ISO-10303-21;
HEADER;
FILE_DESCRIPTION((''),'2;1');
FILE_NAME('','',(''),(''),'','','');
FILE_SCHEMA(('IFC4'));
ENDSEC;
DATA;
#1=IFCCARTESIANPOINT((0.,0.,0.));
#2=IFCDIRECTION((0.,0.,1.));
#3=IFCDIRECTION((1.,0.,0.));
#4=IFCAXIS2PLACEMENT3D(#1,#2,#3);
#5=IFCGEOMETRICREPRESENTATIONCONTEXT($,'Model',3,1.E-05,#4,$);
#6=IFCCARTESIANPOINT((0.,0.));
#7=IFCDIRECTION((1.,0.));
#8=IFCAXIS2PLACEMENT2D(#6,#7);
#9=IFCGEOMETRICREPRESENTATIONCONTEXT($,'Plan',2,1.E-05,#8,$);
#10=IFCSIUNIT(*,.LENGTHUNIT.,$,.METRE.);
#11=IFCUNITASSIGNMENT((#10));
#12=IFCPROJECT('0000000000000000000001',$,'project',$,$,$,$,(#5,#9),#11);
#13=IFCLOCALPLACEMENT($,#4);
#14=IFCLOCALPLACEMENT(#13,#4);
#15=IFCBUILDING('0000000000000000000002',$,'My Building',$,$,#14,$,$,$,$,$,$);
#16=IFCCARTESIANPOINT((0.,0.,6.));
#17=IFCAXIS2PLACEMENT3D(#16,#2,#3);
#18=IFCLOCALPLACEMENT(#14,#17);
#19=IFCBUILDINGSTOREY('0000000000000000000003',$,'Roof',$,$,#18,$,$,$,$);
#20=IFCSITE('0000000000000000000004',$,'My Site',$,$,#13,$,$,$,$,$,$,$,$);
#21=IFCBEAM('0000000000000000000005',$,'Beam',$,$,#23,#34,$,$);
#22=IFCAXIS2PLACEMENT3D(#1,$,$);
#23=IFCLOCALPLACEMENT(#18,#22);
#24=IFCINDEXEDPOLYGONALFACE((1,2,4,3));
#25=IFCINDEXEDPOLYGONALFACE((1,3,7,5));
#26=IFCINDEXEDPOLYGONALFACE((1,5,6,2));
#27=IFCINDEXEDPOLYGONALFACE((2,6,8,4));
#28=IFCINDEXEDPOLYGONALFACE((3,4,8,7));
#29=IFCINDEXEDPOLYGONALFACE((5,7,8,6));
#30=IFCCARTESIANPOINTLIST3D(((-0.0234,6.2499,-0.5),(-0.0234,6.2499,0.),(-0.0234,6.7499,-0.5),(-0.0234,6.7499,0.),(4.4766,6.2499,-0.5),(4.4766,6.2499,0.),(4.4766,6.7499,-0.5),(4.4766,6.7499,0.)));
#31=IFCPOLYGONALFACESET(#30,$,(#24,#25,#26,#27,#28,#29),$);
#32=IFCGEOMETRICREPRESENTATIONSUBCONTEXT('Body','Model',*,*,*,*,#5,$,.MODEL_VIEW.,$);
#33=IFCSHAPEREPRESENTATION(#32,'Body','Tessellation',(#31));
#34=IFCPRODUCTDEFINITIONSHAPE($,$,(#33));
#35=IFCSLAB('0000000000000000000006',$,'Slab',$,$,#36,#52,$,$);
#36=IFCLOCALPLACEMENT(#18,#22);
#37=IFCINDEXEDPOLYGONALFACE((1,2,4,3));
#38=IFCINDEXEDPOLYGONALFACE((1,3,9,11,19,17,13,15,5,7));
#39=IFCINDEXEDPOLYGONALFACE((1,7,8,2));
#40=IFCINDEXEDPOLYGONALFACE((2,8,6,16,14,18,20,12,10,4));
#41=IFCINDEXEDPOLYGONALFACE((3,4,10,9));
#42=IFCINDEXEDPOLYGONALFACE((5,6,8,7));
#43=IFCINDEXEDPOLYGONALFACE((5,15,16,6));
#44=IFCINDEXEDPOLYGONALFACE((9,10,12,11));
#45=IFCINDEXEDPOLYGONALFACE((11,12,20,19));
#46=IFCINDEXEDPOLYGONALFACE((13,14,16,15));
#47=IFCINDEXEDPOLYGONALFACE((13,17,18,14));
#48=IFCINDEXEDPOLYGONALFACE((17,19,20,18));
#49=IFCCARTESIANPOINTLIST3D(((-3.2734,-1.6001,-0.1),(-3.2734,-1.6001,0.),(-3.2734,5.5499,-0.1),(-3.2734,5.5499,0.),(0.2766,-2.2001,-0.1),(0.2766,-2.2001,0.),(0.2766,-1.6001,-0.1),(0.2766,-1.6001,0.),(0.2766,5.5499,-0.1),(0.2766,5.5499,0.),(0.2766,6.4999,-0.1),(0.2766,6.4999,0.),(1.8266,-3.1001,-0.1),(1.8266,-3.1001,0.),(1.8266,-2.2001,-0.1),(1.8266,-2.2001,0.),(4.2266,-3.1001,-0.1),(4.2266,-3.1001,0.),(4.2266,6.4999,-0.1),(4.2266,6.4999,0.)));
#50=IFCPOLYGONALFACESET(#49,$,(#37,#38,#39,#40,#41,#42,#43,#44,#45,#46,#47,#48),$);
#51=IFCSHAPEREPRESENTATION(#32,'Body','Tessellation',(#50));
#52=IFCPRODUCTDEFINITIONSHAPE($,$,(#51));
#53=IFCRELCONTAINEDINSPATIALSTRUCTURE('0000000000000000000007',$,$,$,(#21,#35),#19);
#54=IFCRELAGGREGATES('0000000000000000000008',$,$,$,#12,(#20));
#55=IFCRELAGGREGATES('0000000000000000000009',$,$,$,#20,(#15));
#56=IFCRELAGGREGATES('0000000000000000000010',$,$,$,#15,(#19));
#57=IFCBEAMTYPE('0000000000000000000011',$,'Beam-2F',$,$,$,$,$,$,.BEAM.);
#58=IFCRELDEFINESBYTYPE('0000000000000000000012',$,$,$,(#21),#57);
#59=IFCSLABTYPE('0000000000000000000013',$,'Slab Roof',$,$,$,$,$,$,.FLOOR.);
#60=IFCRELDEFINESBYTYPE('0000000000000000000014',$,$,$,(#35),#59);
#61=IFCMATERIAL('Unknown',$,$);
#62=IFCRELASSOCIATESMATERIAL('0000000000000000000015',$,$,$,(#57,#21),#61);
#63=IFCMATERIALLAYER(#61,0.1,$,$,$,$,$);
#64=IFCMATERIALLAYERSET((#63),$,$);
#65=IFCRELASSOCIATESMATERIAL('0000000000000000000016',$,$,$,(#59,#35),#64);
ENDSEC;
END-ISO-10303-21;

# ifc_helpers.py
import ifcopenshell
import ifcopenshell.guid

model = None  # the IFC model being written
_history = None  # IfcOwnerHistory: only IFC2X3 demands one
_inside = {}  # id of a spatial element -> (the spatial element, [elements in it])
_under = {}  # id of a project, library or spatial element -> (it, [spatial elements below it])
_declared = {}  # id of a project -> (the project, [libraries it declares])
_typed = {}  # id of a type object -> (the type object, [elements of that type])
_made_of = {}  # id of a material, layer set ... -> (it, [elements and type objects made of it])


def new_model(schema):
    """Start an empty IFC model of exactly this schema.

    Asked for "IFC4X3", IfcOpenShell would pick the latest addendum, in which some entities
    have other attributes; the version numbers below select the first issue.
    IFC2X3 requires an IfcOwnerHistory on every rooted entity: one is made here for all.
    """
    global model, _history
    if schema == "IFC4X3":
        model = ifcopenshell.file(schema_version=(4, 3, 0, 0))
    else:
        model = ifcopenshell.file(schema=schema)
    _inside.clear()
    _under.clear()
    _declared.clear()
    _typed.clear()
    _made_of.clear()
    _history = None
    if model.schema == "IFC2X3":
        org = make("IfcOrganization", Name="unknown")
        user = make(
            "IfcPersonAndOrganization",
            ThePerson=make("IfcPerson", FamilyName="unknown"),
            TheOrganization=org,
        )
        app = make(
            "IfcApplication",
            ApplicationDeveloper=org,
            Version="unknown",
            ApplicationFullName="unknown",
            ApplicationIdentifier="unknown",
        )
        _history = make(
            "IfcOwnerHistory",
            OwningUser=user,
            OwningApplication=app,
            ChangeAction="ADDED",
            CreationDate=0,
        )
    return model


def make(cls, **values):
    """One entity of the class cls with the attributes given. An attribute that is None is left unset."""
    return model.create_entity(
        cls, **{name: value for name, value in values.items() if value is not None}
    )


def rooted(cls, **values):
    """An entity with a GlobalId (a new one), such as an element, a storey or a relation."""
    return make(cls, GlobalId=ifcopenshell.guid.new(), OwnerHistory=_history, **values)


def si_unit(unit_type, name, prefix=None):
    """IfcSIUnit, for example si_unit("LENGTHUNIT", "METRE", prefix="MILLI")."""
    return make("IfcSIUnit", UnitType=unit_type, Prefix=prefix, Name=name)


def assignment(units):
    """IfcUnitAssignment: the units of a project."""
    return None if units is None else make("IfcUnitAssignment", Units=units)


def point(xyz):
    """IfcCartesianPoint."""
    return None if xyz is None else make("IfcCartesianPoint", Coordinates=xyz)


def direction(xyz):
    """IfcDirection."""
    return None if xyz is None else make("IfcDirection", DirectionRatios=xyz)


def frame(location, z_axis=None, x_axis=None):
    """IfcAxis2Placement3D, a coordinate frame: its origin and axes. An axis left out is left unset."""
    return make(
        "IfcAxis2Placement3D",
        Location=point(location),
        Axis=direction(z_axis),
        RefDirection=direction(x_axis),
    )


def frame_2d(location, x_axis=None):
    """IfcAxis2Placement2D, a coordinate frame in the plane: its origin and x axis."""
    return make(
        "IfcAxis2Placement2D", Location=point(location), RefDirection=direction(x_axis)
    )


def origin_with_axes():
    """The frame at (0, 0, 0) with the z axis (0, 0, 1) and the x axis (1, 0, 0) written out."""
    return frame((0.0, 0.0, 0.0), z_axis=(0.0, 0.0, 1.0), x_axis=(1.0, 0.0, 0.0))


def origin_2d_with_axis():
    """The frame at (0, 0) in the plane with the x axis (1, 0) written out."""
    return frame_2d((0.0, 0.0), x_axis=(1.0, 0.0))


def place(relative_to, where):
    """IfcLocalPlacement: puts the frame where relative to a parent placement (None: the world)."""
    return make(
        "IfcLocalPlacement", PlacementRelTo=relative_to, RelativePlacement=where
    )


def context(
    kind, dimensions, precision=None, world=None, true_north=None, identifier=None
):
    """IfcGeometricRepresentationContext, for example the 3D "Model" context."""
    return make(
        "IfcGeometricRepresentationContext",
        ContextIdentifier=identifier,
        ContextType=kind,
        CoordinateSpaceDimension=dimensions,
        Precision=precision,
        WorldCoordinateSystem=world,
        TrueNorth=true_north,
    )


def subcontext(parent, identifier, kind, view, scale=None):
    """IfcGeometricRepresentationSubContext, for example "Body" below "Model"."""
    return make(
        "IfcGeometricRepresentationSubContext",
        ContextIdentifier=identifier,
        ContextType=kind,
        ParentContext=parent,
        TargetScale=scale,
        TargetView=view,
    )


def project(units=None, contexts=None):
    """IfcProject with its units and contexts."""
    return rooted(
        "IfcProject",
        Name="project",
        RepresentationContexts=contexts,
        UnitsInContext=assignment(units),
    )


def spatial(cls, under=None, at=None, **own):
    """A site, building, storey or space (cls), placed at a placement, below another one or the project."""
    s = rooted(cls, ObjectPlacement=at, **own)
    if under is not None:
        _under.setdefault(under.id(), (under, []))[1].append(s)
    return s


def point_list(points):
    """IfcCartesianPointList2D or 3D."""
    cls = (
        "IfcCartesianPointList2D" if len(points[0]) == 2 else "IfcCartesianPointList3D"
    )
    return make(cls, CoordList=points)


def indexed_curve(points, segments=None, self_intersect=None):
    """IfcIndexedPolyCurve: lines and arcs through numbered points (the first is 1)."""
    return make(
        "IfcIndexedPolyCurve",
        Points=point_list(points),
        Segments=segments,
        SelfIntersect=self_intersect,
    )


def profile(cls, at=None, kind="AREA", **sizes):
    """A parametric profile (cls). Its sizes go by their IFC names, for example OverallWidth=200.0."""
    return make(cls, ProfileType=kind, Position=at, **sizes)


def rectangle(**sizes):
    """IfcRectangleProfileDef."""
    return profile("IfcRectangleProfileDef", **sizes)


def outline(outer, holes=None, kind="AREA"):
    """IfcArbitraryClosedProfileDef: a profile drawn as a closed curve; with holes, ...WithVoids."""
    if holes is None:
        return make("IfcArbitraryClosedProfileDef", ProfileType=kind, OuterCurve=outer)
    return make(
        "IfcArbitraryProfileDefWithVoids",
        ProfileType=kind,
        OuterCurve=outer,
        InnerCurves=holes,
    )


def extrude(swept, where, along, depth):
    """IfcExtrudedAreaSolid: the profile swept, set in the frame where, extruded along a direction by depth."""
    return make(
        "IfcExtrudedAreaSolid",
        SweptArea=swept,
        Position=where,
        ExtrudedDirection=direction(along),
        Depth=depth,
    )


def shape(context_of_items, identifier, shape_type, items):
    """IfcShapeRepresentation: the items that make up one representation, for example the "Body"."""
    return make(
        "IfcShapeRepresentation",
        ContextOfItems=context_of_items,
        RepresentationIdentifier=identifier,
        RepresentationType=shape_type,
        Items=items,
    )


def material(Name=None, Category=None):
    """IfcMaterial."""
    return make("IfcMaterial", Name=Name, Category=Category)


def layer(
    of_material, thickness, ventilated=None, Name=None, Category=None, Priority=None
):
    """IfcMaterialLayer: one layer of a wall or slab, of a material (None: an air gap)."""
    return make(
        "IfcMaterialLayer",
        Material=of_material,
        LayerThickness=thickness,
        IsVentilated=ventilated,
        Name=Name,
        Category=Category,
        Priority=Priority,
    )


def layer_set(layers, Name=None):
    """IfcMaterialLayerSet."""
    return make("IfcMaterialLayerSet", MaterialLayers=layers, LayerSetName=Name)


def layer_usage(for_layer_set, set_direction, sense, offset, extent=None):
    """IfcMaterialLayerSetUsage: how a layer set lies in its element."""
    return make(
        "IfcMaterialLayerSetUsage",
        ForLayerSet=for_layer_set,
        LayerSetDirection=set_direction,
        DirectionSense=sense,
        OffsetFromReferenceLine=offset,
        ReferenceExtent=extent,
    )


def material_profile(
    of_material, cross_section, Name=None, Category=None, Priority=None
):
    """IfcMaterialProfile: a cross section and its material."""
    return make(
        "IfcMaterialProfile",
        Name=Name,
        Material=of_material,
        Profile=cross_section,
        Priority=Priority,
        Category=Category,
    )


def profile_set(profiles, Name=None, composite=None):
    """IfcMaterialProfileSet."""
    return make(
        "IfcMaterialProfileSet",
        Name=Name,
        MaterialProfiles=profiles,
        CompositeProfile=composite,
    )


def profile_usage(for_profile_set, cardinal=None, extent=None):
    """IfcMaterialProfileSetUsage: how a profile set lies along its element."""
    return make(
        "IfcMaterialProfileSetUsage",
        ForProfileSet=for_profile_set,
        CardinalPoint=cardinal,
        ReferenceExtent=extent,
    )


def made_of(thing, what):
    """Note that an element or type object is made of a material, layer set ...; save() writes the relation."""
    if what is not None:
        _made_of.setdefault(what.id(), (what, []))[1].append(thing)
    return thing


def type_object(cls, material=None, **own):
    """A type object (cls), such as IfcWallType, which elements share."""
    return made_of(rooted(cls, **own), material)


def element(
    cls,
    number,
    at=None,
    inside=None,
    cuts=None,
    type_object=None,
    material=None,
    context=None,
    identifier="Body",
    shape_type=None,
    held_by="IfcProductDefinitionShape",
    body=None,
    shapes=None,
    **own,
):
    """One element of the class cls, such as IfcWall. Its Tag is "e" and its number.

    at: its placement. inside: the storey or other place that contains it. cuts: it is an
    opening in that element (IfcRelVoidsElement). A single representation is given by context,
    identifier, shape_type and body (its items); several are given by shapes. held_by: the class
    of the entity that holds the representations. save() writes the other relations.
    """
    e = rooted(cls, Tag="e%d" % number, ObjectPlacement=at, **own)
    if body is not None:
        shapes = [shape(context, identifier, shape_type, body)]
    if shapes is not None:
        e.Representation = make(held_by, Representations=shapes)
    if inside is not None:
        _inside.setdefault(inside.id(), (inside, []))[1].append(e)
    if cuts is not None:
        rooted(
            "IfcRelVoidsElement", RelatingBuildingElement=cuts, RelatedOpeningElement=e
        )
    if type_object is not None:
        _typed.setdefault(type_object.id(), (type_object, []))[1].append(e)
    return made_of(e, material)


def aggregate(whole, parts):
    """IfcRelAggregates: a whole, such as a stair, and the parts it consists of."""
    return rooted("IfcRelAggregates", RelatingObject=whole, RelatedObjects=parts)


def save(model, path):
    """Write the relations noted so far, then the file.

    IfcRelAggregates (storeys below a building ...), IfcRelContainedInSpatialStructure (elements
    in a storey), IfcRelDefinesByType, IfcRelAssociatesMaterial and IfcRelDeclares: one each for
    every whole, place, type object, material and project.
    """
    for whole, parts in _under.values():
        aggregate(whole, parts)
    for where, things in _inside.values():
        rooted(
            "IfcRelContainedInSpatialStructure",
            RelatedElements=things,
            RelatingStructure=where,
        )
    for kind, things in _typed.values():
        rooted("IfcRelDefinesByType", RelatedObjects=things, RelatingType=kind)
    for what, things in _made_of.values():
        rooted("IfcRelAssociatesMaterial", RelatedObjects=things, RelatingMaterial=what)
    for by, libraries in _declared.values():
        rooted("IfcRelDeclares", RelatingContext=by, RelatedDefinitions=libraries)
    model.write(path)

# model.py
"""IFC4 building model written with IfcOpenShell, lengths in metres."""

from ifc_helpers import new_model, si_unit, frame, origin_with_axes, origin_2d_with_axis, place, context, subcontext, project, spatial, indexed_curve, rectangle, outline, extrude, material, layer, layer_set, layer_usage, material_profile, profile_set, profile_usage, type_object, element, save


model = new_model("IFC4")

# Units and contexts
model_context = context("Model", 3, precision=1e-05, world=origin_with_axes())
plan_context = context("Plan", 2, precision=1e-05, world=origin_2d_with_axis())
body_context = subcontext(model_context, "Body", "Model", "MODEL_VIEW")
ifc_project = project(units=[si_unit("LENGTHUNIT", "METRE")], contexts=[model_context, plan_context])

# Site, building, storey
site_placement = place(None, origin_with_axes())
site = spatial("IfcSite", under=ifc_project, at=site_placement, Name="My Site")
building_placement = place(site_placement, origin_with_axes())
building = spatial("IfcBuilding", under=site, at=building_placement, Name="My Building")
storey_placement = place(building_placement, frame((0.0, 0.0, 6.0), z_axis=(0.0, 0.0, 1.0), x_axis=(1.0, 0.0, 0.0)))
storey = spatial("IfcBuildingStorey", under=building, at=storey_placement, Name="Roof")

# Beam
ifc_material = material(Name="Unknown")
ifc_material_profile = material_profile(ifc_material, rectangle(XDim=0.5, YDim=0.5))
ifc_profile_set = profile_set([ifc_material_profile])
ifc_profile_usage = profile_usage(ifc_profile_set, cardinal=5)
beam_type = type_object("IfcBeamType", Name="Beam-2F", PredefinedType="BEAM", material=ifc_profile_set)
beam_placement = place(storey_placement, frame((-0.0234, 6.4999, -0.25), z_axis=(1.0, -0.000001, 0.000001), x_axis=(0.000001, 1.0, 0.0)))
element("IfcBeam", 1, at=beam_placement, inside=storey, type_object=beam_type, material=ifc_profile_usage, Name="Beam", context=body_context, shape_type="SweptSolid", body=[
    extrude(rectangle(XDim=0.5, YDim=0.5), origin_with_axes(), (0.0, 0.0, 1.0), 4.5),
])

# Slab
ifc_layer = layer(ifc_material, 0.1)
ifc_layer_set = layer_set([ifc_layer])
ifc_layer_usage = layer_usage(ifc_layer_set, "AXIS3", "POSITIVE", -0.1)
slab_type = type_object("IfcSlabType", Name="Slab Roof", PredefinedType="FLOOR", material=ifc_layer_set)
slab_placement = place(storey_placement, frame((4.2266, -3.1001, 0.0), z_axis=(0.0, 0.0, 1.0), x_axis=(1.0, 0.0, 0.0)))
element("IfcSlab", 2, at=slab_placement, inside=storey, type_object=slab_type, material=ifc_layer_usage, Name="Slab", context=body_context, shape_type="SweptSolid", body=[
    extrude(outline(indexed_curve([(0.0, 0.0), (0.0, 9.6), (-3.95, 9.6), (-3.95, 8.65), (-7.5, 8.65), (-7.5, 1.5), (-3.95, 1.5), (-3.95, 0.9), (-2.4, 0.9), (-2.4, 0.0), (0.0, 0.0)])), frame((0.0, 0.0, -0.1), z_axis=(0.0, 0.0, 1.0), x_axis=(1.0, 0.0, 0.0)), (0.0, 0.0, 1.0), 0.1),
])

save(model, "model.ifc")
